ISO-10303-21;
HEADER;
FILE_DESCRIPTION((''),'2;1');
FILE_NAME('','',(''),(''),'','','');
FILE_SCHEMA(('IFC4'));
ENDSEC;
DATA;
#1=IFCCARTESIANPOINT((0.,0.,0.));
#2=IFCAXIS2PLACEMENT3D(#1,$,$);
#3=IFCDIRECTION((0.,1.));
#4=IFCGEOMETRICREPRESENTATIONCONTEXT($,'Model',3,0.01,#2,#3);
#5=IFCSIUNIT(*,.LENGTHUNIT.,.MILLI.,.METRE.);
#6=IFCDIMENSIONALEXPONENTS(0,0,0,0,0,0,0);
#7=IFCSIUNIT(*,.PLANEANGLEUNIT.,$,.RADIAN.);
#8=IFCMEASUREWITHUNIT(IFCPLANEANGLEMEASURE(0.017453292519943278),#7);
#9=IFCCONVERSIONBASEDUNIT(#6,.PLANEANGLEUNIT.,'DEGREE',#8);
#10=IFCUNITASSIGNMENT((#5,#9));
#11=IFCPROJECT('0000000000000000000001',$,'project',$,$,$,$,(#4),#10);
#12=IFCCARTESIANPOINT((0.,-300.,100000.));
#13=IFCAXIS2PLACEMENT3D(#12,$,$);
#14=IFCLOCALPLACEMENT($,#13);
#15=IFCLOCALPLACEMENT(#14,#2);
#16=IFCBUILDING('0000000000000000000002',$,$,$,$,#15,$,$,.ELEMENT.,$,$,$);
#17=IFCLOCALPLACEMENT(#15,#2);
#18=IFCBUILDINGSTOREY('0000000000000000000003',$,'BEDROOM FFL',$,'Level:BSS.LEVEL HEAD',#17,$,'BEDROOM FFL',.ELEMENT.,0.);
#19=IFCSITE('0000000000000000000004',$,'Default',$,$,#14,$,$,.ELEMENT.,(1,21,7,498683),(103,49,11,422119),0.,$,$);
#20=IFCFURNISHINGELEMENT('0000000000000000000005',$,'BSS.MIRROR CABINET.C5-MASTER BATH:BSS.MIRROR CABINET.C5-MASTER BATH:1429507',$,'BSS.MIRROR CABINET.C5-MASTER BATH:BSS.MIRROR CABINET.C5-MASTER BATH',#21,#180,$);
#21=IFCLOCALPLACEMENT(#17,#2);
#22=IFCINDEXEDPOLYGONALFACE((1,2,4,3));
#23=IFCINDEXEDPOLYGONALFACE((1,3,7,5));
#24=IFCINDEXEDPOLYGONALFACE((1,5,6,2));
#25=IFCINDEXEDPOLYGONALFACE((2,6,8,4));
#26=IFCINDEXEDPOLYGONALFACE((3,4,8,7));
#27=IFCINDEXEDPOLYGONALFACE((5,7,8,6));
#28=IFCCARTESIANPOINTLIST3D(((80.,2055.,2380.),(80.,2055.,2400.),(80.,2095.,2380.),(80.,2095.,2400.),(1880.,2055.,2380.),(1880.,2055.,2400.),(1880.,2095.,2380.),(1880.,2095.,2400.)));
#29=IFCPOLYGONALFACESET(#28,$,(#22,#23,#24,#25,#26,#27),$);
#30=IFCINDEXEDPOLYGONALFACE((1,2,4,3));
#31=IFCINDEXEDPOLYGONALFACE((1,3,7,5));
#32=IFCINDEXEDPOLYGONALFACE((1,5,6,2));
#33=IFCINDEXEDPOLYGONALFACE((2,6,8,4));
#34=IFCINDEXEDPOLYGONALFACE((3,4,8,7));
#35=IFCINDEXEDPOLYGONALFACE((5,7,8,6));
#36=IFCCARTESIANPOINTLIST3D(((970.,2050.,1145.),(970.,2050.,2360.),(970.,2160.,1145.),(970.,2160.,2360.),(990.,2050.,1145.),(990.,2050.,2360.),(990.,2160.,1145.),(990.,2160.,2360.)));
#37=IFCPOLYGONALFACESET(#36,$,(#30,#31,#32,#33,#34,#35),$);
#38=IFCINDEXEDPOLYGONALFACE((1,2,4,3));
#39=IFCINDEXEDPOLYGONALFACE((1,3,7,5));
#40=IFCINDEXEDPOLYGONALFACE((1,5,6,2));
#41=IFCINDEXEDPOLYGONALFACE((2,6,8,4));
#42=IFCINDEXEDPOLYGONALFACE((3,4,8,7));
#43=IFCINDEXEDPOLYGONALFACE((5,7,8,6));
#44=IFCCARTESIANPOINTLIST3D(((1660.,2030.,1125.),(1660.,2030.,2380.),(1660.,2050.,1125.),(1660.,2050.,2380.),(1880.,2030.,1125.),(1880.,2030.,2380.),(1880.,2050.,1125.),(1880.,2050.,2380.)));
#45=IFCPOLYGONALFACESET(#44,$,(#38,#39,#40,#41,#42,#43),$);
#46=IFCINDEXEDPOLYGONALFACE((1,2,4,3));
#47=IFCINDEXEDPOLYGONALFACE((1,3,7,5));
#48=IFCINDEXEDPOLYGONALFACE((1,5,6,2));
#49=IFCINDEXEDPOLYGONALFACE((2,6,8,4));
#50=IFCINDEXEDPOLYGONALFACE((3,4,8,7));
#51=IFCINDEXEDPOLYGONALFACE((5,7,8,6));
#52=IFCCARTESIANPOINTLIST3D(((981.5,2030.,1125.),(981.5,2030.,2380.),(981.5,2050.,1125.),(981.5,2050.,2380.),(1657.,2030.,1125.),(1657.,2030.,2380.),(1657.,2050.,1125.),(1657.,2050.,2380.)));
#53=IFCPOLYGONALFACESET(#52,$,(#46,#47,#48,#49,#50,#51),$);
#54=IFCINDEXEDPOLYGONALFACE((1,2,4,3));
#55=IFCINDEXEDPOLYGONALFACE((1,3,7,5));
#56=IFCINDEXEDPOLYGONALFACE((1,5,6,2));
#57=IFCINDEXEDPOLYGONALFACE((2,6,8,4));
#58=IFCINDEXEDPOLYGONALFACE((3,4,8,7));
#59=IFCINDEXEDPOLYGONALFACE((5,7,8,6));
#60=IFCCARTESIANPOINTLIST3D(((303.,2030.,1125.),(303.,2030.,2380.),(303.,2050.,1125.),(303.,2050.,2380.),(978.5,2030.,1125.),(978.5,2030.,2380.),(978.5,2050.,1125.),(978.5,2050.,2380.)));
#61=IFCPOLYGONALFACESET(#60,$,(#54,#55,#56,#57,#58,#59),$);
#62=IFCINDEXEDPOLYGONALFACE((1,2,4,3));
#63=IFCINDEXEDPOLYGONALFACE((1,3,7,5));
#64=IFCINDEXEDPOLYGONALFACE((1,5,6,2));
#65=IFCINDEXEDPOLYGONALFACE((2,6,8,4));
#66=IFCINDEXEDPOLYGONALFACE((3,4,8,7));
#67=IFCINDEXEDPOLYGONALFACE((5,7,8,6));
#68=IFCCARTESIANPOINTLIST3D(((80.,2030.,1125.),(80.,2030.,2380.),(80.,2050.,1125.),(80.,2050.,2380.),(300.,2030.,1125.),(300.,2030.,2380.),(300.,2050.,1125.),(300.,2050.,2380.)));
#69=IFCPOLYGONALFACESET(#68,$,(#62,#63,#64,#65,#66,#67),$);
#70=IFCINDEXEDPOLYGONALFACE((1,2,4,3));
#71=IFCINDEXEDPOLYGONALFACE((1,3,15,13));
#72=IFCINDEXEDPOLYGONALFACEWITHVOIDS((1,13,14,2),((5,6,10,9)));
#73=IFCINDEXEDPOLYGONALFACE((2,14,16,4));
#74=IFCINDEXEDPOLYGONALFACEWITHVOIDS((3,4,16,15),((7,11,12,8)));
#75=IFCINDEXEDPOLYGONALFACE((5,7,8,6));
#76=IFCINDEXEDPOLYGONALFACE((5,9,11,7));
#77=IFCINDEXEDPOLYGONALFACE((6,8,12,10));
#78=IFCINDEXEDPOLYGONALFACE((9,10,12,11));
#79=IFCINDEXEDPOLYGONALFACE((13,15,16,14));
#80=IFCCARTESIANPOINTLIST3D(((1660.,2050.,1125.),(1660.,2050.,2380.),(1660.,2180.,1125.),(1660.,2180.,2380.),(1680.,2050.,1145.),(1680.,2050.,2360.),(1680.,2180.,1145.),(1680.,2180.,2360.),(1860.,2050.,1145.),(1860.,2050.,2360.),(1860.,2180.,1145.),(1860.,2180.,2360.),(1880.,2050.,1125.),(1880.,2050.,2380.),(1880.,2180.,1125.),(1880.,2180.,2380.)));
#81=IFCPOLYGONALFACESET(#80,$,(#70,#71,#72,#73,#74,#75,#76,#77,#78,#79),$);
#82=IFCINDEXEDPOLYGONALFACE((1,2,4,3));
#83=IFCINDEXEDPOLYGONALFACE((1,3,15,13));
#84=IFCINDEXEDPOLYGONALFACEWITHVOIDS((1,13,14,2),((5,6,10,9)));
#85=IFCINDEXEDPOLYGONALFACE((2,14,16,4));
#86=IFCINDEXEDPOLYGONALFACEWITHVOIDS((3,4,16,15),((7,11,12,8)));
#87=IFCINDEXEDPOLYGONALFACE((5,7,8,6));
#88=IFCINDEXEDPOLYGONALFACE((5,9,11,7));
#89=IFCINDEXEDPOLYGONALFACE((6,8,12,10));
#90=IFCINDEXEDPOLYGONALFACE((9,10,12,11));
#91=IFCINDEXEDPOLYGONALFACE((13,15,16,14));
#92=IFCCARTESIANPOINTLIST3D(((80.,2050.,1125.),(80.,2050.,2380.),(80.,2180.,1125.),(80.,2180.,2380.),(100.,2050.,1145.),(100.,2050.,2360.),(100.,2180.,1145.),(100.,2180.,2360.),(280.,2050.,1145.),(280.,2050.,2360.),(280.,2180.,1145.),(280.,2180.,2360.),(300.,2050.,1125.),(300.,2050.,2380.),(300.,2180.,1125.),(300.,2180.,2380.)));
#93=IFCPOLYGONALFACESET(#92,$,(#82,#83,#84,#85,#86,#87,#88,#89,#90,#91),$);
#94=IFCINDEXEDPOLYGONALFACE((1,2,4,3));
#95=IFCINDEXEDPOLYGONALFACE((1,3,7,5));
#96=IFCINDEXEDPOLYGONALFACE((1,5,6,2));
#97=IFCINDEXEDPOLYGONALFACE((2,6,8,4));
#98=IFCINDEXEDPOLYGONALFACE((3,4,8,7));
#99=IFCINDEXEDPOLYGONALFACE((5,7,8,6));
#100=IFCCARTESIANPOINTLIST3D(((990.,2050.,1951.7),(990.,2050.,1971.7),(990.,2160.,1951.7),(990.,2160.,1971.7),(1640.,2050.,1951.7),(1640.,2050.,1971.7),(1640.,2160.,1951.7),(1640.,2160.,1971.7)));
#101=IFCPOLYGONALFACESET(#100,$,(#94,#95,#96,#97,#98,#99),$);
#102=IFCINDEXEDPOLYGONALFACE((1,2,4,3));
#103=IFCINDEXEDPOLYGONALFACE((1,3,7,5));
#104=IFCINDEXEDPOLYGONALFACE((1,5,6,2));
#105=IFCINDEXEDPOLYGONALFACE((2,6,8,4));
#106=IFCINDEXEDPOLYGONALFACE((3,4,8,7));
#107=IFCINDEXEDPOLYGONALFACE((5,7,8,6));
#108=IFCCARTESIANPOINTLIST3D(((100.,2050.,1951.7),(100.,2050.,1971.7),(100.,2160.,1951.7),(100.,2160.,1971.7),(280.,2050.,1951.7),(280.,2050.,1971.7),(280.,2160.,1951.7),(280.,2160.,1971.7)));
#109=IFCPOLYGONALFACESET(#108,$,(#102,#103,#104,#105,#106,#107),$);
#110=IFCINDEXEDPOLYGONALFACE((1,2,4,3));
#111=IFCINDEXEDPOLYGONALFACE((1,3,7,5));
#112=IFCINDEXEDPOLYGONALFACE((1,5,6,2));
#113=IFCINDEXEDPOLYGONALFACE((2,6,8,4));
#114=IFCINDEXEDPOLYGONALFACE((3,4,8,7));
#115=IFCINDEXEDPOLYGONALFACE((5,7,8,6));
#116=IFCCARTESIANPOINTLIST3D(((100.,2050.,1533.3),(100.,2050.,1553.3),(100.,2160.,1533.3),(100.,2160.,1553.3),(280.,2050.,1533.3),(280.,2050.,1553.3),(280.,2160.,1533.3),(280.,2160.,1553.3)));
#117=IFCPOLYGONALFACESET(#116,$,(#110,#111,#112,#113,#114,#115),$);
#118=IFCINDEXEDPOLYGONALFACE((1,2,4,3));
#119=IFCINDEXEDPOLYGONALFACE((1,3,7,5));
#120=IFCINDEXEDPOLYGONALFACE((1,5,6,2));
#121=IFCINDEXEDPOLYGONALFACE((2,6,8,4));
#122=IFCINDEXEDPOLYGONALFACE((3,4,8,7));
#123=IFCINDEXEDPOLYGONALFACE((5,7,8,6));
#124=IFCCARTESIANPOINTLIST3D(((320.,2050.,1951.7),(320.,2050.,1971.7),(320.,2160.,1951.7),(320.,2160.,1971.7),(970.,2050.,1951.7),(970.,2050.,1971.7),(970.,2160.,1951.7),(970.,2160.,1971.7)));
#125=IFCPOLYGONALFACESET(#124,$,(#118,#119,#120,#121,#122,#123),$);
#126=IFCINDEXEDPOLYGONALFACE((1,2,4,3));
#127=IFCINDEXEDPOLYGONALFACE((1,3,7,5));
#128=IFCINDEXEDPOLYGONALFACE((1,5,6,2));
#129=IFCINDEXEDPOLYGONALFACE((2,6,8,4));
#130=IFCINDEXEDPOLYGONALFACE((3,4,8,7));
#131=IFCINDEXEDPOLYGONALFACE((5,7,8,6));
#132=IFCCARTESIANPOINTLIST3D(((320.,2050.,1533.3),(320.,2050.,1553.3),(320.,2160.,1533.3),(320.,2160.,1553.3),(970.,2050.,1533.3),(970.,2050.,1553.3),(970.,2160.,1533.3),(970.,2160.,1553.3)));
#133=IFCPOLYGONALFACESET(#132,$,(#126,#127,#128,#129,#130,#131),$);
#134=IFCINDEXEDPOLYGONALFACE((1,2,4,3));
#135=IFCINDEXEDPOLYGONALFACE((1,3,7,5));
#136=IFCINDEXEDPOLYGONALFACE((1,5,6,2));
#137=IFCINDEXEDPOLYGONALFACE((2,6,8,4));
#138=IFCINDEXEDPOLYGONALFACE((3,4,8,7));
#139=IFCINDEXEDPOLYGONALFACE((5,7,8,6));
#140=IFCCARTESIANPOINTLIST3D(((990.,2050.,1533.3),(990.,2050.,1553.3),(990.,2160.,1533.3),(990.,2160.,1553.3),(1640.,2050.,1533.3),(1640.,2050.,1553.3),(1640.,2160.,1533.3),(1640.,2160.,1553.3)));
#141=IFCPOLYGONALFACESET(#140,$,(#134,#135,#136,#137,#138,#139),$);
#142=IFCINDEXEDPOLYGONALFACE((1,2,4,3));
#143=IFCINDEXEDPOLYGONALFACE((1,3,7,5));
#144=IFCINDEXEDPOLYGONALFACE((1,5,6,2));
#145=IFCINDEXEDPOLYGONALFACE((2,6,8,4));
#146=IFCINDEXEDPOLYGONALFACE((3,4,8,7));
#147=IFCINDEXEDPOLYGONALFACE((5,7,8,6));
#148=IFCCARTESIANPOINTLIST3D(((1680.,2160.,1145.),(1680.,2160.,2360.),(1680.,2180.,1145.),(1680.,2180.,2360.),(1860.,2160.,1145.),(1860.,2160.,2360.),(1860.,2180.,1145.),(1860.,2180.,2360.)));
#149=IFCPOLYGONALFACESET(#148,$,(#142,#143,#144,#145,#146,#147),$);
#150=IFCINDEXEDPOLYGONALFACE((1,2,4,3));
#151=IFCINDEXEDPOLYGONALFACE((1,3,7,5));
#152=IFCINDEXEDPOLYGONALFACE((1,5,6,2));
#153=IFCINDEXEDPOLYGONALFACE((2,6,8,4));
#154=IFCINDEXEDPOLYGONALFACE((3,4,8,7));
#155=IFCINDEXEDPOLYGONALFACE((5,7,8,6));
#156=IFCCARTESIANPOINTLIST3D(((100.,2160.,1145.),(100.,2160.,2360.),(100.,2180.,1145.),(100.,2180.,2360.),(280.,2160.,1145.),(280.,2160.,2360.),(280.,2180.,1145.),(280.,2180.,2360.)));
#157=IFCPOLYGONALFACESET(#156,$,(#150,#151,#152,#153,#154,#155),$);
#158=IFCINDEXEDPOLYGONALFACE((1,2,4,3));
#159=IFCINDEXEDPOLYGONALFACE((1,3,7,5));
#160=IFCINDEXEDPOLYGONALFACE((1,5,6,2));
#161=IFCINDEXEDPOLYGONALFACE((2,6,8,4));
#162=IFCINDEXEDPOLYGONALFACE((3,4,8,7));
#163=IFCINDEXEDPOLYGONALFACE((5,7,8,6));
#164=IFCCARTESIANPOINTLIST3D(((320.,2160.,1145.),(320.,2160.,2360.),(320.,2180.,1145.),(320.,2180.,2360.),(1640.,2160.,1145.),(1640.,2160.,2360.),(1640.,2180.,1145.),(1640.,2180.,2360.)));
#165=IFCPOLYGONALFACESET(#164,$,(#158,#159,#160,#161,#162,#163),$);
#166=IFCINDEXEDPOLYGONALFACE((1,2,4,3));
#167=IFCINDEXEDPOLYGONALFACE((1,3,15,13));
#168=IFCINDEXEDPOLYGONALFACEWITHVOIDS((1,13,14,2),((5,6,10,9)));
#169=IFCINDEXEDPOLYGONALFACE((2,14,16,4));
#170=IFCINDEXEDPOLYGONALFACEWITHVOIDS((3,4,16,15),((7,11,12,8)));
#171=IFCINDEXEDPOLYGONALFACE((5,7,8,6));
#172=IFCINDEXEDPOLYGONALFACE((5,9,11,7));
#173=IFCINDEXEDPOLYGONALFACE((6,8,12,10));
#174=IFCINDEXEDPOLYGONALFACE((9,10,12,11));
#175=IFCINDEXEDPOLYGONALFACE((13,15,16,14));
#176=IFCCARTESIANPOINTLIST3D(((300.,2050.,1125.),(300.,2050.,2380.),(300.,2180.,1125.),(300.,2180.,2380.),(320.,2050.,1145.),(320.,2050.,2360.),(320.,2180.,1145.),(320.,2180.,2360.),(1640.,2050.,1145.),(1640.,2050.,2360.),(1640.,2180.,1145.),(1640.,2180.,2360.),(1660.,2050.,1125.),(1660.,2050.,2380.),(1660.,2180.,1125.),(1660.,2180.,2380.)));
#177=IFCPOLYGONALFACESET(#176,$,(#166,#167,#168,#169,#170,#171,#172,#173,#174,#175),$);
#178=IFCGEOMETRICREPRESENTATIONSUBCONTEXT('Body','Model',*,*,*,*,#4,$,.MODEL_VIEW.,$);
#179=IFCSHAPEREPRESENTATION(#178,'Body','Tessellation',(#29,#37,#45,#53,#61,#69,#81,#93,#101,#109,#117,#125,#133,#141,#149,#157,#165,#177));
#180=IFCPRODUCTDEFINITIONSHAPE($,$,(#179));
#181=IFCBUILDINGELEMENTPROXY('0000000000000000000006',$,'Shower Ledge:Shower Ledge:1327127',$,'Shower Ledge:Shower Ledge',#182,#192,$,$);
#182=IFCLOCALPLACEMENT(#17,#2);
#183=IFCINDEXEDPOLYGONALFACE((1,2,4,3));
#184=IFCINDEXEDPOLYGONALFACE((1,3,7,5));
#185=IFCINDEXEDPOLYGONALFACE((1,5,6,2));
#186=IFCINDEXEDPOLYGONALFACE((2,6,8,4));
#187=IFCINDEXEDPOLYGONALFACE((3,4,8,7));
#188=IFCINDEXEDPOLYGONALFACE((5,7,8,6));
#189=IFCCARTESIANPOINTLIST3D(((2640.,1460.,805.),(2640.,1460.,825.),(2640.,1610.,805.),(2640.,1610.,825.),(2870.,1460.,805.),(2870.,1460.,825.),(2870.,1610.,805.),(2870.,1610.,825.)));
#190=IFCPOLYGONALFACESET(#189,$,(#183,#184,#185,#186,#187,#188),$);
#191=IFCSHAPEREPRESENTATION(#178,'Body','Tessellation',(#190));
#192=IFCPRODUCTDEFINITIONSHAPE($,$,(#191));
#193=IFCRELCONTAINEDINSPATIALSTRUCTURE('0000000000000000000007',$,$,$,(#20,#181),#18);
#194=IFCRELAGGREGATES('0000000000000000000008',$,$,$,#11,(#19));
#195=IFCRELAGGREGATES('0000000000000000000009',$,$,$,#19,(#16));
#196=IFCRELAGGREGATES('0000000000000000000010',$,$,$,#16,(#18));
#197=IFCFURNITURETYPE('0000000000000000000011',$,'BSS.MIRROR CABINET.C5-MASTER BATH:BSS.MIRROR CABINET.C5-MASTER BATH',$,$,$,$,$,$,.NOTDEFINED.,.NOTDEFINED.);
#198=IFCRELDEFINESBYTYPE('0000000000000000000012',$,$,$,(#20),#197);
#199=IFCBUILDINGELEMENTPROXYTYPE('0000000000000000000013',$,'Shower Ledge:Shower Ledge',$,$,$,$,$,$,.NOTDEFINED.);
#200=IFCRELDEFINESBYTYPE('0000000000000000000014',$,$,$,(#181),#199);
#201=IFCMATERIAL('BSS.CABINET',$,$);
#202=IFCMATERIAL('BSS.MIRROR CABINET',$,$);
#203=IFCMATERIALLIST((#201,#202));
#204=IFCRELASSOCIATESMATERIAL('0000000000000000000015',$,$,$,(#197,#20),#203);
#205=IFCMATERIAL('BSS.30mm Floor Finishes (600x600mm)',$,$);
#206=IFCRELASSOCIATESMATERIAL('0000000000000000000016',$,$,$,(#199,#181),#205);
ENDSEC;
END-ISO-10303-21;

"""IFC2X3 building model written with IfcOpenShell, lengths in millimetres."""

from ifc_helpers import new_model, entity, si_unit, converted_unit, direction, frame, frame_2d, origin, origin_2d_with_axis, place, context, subcontext, project, spatial, polyline, rectangle, outline, extrude, source, transform, mapped, material, material_list, type_object, type_shapes, element, save


model = new_model("IFC2X3")

# Units and contexts
model_context = context("Model", 3, precision=0.01, world=origin(), true_north=direction((0.0, 1.0)))
body_context = subcontext(model_context, "Body", "Model", "MODEL_VIEW")
ifc_project = project(units=[si_unit("LENGTHUNIT", "METRE", prefix="MILLI"), converted_unit("PLANEANGLEUNIT", "DEGREE", entity("IfcPlaneAngleMeasure", 0.017453292519943278), si_unit("PLANEANGLEUNIT", "RADIAN"), dimensions=[0, 0, 0, 0, 0, 0, 0])], contexts=[model_context])

# Site, building, storey
site_placement = place(None, frame((0.0, -300.0, 100000.0)))
site = spatial("IfcSite", under=ifc_project, at=site_placement, Name="Default", CompositionType="ELEMENT", RefLatitude=(1, 21, 7, 498683), RefLongitude=(103, 49, 11, 422119), RefElevation=0.0)
building_placement = place(site_placement, origin())
building = spatial("IfcBuilding", under=site, at=building_placement, CompositionType="ELEMENT")
storey_placement = place(building_placement, origin())
storey = spatial("IfcBuildingStorey", under=building, at=storey_placement, Name="BEDROOM FFL", ObjectType="Level:BSS.LEVEL HEAD", LongName="BEDROOM FFL", CompositionType="ELEMENT", Elevation=0.0)

# Shared definitions
ifc_material_1 = material(Name="BSS.30mm Floor Finishes (600x600mm)")

# Furnishing element
ifc_material_2 = material(Name="BSS.CABINET")
ifc_material_3 = material(Name="BSS.MIRROR CABINET")
ifc_material_list = material_list([ifc_material_2, ifc_material_3])
furniture_type = type_object("IfcFurnitureType", Name="BSS.MIRROR CABINET.C5-MASTER BATH:BSS.MIRROR CABINET.C5-MASTER BATH", AssemblyPlace="NOTDEFINED", material=ifc_material_list)
shared_shape_1 = source(origin(), body_context, "Body", "SweptSolid", [
    extrude(rectangle(XDim=1800.0, YDim=40.0, at=origin_2d_with_axis()), frame((0.0, -105.0, 1255.0), z_axis=(0.0, 0.0, 1.0), x_axis=(-1.0, 0.0, 0.0)), (0.0, 0.0, 1.0), 20.0),
    extrude(rectangle(XDim=110.0, YDim=20.0, at=origin_2d_with_axis()), frame((0.0, -75.0, 20.0), z_axis=(0.0, 0.0, 1.0), x_axis=(0.0, 1.0, 0.0)), (0.0, 0.0, 1.0), 1215.0),
    extrude(rectangle(XDim=20.0, YDim=220.0, at=frame_2d((0.0, 0.0), x_axis=(1.0, 0.0))), frame((790.0, -140.0, 0.0), z_axis=(0.0, 0.0, 1.0), x_axis=(0.0, 1.0, 0.0)), (0.0, 0.0, 1.0), 1255.0),
    extrude(rectangle(XDim=20.0, YDim=675.5, at=frame_2d((0.0, 0.0), x_axis=(1.0, 0.0))), frame((339.2, -140.0, 0.0), z_axis=(0.0, 0.0, 1.0), x_axis=(0.0, 1.0, 0.0)), (0.0, 0.0, 1.0), 1255.0),
    extrude(rectangle(XDim=20.0, YDim=675.5, at=frame_2d((0.0, 0.0), x_axis=(1.0, 0.0))), frame((-339.3, -140.0, 0.0), z_axis=(0.0, 0.0, 1.0), x_axis=(0.0, 1.0, 0.0)), (0.0, 0.0, 1.0), 1255.0),
    extrude(rectangle(XDim=20.0, YDim=220.0, at=frame_2d((0.0, 0.0), x_axis=(1.0, 0.0))), frame((-790.0, -140.0, 0.0), z_axis=(0.0, 0.0, 1.0), x_axis=(0.0, 1.0, 0.0)), (0.0, 0.0, 1.0), 1255.0),
    extrude(outline(polyline([(-627.5, -110.0), (627.5, -110.0), (627.5, 110.0), (-627.5, 110.0), (-627.5, -110.0)]), holes=[polyline([(607.5, 90.0), (607.5, -90.0), (-607.5, -90.0), (-607.5, 90.0), (607.5, 90.0)])]), frame((790.0, -130.0, 627.5), z_axis=(0.0, 1.0, 0.0), x_axis=(0.0, 0.0, -1.0)), (0.0, 0.0, 1.0), 130.0),
    extrude(outline(polyline([(-627.5, -110.0), (627.5, -110.0), (627.5, 110.0), (-627.5, 110.0), (-627.5, -110.0)]), holes=[polyline([(607.5, 90.0), (607.5, -90.0), (-607.5, -90.0), (-607.5, 90.0), (607.5, 90.0)])]), frame((-790.0, -130.0, 627.5), z_axis=(0.0, 1.0, 0.0), x_axis=(0.0, 0.0, -1.0)), (0.0, 0.0, 1.0), 130.0),
    extrude(rectangle(XDim=110.0, YDim=650.0, at=origin_2d_with_axis()), frame((335.0, -75.0, 826.7), z_axis=(0.0, 0.0, 1.0), x_axis=(0.0, 1.0, 0.0)), (0.0, 0.0, 1.0), 20.0),
    extrude(rectangle(XDim=110.0, YDim=180.0, at=origin_2d_with_axis()), frame((-790.0, -75.0, 826.7), z_axis=(0.0, 0.0, 1.0), x_axis=(0.0, 1.0, 0.0)), (0.0, 0.0, 1.0), 20.0),
    extrude(rectangle(XDim=110.0, YDim=180.0, at=origin_2d_with_axis()), frame((-790.0, -75.0, 408.3), z_axis=(0.0, 0.0, 1.0), x_axis=(0.0, 1.0, 0.0)), (0.0, 0.0, 1.0), 20.0),
    extrude(rectangle(XDim=110.0, YDim=650.0, at=origin_2d_with_axis()), frame((-335.0, -75.0, 826.7), z_axis=(0.0, 0.0, 1.0), x_axis=(0.0, 1.0, 0.0)), (0.0, 0.0, 1.0), 20.0),
    extrude(rectangle(XDim=110.0, YDim=650.0, at=origin_2d_with_axis()), frame((-335.0, -75.0, 408.3), z_axis=(0.0, 0.0, 1.0), x_axis=(0.0, 1.0, 0.0)), (0.0, 0.0, 1.0), 20.0),
    extrude(rectangle(XDim=110.0, YDim=650.0, at=origin_2d_with_axis()), frame((335.0, -75.0, 408.3), z_axis=(0.0, 0.0, 1.0), x_axis=(0.0, 1.0, 0.0)), (0.0, 0.0, 1.0), 20.0),
    extrude(rectangle(XDim=20.0, YDim=180.0, at=origin_2d_with_axis()), frame((790.0, -10.0, 20.0), z_axis=(0.0, 0.0, 1.0), x_axis=(0.0, 1.0, 0.0)), (0.0, 0.0, 1.0), 1215.0),
    extrude(rectangle(XDim=20.0, YDim=180.0, at=origin_2d_with_axis()), frame((-790.0, -10.0, 20.0), z_axis=(0.0, 0.0, 1.0), x_axis=(0.0, 1.0, 0.0)), (0.0, 0.0, 1.0), 1215.0),
    extrude(rectangle(XDim=20.0, YDim=1320.0, at=origin_2d_with_axis()), frame((0.0, -10.0, 20.0), z_axis=(0.0, 0.0, 1.0), x_axis=(0.0, 1.0, 0.0)), (0.0, 0.0, 1.0), 1215.0),
    extrude(outline(polyline([(-680.0, -627.5), (680.0, -627.5), (680.0, 627.5), (-680.0, 627.5), (-680.0, -627.5)]), holes=[polyline([(660.0, 607.5), (660.0, -607.5), (-660.0, -607.5), (-660.0, 607.5), (660.0, 607.5)])]), frame((0.0, -130.0, 627.5), z_axis=(0.0, 1.0, 0.0), x_axis=(-1.0, 0.0, 0.0)), (0.0, 0.0, 1.0), 130.0),
])
type_shapes(furniture_type, [shared_shape_1])
furnishing_placement = place(storey_placement, frame((980.0, 2180.0, 1125.0)))
element("IfcFurnishingElement", 1, at=furnishing_placement, inside=storey, type_object=furniture_type, material=ifc_material_list, Name="BSS.MIRROR CABINET.C5-MASTER BATH:BSS.MIRROR CABINET.C5-MASTER BATH:1429507", ObjectType="BSS.MIRROR CABINET.C5-MASTER BATH:BSS.MIRROR CABINET.C5-MASTER BATH", context=body_context, shape_type="MappedRepresentation", body=[
    mapped(shared_shape_1, transform((0.0, 0.0, 0.0), scale=1.0)),
])

# Building element proxy
building_element_proxy_type = type_object("IfcBuildingElementProxyType", Name="Shower Ledge:Shower Ledge", PredefinedType="NOTDEFINED", material=ifc_material_1)
shared_shape_2 = source(origin(), body_context, "Body", "SweptSolid", [
    extrude(rectangle(XDim=150.0, YDim=230.0, at=frame_2d((0.0, 0.0), x_axis=(1.0, 0.0))), frame((2755.0, 1535.0, 805.0), z_axis=(0.0, 0.0, 1.0), x_axis=(0.0, -1.0, 0.0)), (0.0, 0.0, 1.0), 20.0),
])
type_shapes(building_element_proxy_type, [shared_shape_2])
proxy_placement = place(storey_placement, origin())
element("IfcBuildingElementProxy", 2, at=proxy_placement, inside=storey, type_object=building_element_proxy_type, material=ifc_material_1, Name="Shower Ledge:Shower Ledge:1327127", ObjectType="Shower Ledge:Shower Ledge", context=body_context, shape_type="MappedRepresentation", body=[
    mapped(shared_shape_2, transform((0.0, 0.0, 0.0), scale=1.0)),
])

save(model, "model.ifc")
